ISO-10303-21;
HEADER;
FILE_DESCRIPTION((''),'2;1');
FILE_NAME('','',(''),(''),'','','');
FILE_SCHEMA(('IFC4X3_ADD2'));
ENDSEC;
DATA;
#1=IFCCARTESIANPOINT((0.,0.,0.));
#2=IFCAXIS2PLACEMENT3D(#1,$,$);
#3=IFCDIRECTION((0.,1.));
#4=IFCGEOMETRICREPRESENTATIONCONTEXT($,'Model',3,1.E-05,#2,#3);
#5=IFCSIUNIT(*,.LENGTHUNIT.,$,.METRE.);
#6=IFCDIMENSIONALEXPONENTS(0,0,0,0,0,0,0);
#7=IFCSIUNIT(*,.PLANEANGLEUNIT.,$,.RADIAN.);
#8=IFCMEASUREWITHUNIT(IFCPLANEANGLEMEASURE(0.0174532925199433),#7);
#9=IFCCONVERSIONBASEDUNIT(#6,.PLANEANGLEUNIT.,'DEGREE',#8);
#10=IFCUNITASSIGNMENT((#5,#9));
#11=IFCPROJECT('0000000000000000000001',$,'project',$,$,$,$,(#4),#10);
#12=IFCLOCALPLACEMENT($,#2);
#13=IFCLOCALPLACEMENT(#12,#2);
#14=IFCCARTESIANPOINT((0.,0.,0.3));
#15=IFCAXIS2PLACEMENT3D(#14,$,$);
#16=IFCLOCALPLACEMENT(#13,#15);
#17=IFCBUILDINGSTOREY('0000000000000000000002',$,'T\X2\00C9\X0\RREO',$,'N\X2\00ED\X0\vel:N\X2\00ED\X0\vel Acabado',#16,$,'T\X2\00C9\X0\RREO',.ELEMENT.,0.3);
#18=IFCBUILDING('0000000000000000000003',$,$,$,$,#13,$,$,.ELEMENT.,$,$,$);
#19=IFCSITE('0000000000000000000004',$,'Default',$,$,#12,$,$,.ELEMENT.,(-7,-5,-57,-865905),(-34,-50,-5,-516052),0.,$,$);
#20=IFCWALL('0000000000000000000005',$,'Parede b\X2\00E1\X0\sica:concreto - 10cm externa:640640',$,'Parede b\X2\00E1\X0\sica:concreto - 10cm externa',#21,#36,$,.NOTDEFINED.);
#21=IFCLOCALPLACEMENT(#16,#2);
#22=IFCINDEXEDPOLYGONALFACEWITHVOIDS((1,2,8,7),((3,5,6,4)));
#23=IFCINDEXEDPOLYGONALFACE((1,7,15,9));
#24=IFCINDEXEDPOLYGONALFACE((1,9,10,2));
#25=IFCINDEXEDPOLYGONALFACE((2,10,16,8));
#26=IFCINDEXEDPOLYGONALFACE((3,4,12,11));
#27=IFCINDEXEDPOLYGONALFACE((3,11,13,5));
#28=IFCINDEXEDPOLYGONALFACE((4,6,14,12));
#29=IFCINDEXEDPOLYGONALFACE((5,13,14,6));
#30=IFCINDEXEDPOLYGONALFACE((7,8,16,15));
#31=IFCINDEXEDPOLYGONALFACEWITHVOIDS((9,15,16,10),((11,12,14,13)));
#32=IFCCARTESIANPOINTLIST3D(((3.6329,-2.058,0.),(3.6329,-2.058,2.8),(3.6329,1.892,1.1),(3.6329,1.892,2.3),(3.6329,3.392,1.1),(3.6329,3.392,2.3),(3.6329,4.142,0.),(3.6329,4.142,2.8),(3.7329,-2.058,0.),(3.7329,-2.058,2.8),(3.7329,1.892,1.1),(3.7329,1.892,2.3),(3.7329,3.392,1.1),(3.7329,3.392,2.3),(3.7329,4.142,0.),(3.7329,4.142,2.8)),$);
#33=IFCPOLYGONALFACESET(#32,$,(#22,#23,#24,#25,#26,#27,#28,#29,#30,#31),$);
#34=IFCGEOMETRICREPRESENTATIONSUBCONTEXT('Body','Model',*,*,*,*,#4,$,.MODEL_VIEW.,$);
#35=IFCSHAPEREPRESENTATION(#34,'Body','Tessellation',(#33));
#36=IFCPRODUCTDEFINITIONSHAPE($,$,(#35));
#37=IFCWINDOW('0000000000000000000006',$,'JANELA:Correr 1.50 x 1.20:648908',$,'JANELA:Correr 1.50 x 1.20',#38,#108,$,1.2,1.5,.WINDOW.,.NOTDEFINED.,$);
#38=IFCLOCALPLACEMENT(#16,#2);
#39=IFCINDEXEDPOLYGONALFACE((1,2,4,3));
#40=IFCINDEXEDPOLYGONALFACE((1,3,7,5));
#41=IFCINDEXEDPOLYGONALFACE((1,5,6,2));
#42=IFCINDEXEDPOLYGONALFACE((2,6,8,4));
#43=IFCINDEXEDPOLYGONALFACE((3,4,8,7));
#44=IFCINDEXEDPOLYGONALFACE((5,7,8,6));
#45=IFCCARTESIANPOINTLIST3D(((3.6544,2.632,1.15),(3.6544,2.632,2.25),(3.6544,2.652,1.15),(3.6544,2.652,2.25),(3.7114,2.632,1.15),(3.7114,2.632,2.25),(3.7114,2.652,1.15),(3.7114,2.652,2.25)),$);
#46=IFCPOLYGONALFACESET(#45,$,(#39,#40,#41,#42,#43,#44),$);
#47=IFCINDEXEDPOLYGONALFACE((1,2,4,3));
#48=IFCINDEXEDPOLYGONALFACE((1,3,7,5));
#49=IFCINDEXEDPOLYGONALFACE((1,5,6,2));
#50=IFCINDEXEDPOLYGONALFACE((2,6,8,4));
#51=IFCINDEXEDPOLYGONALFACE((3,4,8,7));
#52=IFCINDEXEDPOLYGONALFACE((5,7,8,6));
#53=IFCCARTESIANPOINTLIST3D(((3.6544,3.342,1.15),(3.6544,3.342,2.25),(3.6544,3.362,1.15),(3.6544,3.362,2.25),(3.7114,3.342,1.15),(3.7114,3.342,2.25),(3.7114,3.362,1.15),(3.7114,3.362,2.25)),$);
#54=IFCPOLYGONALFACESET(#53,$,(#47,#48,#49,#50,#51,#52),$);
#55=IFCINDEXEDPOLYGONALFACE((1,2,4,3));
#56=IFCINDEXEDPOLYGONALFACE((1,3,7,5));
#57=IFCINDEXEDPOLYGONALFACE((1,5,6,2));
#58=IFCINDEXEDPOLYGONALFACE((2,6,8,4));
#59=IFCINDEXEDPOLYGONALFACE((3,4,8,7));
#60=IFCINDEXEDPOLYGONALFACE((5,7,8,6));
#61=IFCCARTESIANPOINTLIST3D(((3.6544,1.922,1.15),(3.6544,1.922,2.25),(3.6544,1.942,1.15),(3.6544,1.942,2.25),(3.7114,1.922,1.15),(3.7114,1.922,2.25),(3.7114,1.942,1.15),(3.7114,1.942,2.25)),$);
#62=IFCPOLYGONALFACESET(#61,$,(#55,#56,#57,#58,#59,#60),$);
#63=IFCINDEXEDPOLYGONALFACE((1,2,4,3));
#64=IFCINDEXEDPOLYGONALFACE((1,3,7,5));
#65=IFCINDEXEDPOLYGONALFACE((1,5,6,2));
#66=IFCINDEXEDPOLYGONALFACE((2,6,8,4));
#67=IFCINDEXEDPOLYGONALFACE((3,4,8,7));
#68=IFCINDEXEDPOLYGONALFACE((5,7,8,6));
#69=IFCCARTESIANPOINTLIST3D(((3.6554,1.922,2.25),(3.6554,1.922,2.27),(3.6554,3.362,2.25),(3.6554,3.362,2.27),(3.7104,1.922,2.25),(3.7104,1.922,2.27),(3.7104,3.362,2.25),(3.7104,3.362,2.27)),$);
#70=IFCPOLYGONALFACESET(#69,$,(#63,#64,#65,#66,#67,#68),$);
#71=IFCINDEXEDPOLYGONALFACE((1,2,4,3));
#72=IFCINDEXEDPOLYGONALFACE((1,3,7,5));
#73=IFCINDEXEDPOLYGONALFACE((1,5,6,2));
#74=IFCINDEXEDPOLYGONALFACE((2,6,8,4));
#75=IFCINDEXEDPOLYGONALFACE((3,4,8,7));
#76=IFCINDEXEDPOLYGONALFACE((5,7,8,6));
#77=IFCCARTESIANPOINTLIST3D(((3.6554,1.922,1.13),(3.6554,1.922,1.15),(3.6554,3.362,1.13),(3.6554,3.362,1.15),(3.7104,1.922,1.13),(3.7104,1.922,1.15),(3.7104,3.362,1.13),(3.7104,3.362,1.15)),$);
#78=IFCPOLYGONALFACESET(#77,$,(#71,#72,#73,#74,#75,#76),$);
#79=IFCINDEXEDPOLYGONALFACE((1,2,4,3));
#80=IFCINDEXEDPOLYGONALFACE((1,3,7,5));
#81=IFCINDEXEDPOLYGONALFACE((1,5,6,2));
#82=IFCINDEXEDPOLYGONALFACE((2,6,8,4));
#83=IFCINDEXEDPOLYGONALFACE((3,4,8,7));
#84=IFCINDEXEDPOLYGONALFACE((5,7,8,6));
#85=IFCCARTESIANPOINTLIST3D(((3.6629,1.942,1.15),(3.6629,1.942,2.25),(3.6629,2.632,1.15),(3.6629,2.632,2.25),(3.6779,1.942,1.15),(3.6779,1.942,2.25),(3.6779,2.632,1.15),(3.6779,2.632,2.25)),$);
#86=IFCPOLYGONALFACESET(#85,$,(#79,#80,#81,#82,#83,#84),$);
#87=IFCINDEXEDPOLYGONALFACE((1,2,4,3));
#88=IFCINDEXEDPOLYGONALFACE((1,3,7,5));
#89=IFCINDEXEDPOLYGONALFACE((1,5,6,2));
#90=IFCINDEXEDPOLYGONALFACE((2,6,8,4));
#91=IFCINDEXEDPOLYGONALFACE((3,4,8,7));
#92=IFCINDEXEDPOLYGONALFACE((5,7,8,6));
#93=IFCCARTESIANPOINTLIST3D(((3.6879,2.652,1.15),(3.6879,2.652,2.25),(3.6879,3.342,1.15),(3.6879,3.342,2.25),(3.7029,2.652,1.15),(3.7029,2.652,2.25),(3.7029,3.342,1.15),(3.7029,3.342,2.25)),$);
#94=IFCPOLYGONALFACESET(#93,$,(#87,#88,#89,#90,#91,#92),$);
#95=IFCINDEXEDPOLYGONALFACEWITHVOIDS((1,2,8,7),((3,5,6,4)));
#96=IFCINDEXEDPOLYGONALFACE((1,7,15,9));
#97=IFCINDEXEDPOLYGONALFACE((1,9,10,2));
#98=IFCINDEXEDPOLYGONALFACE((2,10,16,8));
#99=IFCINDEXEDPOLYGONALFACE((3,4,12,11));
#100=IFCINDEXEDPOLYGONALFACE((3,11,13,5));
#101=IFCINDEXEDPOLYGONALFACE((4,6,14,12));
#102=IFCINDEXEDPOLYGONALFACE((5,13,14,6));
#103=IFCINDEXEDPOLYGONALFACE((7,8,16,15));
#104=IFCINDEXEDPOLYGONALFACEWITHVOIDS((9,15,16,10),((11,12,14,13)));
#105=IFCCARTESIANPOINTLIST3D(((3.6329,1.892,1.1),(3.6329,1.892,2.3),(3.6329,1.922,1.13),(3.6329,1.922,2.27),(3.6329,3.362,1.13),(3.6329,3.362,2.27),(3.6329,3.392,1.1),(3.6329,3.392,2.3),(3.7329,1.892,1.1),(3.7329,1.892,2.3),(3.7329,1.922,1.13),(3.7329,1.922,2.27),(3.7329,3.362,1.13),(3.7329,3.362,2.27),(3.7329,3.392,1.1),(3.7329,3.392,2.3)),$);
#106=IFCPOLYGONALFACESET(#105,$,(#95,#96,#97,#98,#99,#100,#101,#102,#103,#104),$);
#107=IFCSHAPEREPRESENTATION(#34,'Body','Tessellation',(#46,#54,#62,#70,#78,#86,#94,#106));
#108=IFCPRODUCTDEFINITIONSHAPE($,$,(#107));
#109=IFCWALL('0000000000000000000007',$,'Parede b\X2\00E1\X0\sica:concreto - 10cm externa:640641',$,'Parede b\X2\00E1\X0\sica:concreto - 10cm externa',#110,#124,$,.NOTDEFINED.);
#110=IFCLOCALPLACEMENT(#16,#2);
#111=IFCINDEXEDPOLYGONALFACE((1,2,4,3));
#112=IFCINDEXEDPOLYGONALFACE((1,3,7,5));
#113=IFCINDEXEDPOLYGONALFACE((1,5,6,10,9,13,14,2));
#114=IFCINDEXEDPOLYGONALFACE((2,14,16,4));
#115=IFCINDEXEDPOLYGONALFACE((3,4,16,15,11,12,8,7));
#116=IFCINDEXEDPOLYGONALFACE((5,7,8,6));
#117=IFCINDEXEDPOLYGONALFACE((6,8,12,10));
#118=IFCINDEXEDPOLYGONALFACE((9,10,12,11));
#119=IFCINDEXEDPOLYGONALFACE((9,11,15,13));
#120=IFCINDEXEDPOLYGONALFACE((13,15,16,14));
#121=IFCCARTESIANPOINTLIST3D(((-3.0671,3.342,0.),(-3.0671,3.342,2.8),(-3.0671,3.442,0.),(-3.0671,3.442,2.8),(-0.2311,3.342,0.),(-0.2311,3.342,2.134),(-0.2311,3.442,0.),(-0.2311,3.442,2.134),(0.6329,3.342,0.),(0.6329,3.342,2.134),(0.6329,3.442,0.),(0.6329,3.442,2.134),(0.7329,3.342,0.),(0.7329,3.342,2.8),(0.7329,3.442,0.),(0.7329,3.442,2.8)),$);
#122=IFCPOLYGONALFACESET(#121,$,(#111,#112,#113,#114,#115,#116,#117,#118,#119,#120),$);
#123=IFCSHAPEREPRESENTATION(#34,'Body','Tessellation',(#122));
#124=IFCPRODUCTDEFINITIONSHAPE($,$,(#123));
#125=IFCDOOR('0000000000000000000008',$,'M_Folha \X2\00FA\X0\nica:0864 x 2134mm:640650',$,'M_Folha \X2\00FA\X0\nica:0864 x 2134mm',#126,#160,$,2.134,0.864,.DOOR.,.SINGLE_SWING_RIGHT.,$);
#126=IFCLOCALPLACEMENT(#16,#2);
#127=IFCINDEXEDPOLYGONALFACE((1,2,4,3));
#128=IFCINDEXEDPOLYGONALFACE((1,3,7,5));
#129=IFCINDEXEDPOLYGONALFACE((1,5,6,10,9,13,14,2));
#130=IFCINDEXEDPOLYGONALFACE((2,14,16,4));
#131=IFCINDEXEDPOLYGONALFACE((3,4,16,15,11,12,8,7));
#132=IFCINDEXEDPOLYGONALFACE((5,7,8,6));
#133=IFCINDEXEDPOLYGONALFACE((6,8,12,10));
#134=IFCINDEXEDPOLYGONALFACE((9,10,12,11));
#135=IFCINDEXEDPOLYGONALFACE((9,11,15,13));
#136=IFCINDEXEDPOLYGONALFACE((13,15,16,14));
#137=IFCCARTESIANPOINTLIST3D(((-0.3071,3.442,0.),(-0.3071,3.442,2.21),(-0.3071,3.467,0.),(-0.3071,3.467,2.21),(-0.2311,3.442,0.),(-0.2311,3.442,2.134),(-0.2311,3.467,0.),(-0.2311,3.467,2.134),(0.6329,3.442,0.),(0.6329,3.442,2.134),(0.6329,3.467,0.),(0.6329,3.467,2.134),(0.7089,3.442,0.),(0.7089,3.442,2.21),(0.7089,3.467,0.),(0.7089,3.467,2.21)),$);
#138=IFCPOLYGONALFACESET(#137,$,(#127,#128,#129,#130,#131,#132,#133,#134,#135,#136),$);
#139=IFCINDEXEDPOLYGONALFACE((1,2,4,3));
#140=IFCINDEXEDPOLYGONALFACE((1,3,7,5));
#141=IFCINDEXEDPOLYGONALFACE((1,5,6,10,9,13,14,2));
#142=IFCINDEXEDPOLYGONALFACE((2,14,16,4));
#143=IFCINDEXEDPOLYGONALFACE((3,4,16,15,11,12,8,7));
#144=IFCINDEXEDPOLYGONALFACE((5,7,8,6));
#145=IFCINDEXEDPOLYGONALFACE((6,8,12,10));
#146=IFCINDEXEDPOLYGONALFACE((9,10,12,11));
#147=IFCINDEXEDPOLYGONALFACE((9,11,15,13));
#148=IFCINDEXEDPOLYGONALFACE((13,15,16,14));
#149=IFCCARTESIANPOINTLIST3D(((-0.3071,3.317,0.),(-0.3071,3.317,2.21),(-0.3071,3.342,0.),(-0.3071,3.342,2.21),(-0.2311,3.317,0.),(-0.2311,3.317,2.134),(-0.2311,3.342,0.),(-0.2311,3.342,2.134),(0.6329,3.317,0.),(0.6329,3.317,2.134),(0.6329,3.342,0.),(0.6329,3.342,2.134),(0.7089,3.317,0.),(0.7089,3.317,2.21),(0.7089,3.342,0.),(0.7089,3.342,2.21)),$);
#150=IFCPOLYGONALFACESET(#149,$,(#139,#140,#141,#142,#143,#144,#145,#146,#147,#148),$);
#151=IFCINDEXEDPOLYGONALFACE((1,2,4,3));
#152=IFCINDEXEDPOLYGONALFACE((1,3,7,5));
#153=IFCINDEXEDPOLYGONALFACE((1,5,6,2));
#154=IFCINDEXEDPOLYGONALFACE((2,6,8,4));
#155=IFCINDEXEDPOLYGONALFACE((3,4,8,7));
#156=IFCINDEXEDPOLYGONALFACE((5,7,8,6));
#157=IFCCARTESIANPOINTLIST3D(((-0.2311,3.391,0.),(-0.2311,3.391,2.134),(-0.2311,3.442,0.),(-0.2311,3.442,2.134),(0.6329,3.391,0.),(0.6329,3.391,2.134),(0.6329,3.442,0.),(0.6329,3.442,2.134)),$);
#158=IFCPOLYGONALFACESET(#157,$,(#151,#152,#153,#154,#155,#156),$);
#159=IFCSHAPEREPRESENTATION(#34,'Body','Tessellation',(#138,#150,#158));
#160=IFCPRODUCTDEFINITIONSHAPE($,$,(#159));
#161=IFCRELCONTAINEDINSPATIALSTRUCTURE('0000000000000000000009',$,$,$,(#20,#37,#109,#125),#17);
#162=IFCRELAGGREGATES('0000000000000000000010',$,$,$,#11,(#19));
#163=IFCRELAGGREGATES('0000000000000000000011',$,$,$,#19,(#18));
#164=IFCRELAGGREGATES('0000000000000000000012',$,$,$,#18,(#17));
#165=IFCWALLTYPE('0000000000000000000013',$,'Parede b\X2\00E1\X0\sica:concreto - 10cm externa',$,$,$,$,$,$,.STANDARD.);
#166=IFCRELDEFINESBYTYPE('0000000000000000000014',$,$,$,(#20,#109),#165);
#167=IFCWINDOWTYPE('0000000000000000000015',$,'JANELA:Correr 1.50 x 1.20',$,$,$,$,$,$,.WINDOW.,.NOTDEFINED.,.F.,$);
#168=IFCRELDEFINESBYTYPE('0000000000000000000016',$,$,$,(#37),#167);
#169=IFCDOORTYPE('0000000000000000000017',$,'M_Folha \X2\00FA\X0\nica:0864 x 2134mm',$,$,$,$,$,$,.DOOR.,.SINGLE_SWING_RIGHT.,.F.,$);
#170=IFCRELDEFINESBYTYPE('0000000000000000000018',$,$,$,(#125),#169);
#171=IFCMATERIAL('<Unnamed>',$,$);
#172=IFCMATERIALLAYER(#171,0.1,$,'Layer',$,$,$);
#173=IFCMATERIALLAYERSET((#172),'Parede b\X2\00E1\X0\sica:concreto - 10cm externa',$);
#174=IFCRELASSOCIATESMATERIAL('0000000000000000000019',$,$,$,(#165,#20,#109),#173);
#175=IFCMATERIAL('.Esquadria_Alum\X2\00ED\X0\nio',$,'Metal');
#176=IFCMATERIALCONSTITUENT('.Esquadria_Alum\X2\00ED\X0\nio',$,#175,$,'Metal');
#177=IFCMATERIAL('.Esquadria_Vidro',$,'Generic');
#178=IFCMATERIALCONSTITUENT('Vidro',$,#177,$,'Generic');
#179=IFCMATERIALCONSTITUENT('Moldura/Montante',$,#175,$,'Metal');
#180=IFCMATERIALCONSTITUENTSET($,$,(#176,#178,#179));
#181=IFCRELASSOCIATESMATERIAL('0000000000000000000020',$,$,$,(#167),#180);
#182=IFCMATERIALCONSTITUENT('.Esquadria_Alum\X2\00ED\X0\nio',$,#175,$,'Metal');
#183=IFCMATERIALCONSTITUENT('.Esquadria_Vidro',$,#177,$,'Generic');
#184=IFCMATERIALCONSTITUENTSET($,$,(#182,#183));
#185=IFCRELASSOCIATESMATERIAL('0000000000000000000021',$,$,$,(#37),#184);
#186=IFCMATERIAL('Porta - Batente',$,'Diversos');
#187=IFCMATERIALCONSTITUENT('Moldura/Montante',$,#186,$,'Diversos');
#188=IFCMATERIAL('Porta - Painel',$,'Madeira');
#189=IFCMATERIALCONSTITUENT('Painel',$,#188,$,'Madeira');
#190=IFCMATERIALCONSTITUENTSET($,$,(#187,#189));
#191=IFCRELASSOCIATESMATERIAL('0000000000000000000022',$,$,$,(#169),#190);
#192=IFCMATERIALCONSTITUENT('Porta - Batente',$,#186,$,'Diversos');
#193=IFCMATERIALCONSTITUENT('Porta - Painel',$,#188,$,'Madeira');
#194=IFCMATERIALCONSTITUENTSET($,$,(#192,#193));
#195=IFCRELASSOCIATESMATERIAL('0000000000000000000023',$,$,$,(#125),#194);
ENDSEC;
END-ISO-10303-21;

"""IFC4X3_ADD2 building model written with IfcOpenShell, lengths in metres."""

from ifc_helpers import new_model, entity, si_unit, converted_unit, direction, frame, frame_2d, origin, origin_2d_with_axis, place, context, subcontext, project, spatial, polyline, rectangle, outline, extrude, source, transform, mapped, material, layer, layer_set, constituent, constituent_set, type_object, type_shapes, element, fill, save


model = new_model("IFC4X3_ADD2")

# Units and contexts
model_context = context("Model", 3, precision=1e-05, world=origin(), true_north=direction((0.0, 1.0)))
body_context = subcontext(model_context, "Body", "Model", "MODEL_VIEW")
ifc_project = project(units=[si_unit("LENGTHUNIT", "METRE"), converted_unit("PLANEANGLEUNIT", "DEGREE", entity("IfcPlaneAngleMeasure", 0.0174532925199433), si_unit("PLANEANGLEUNIT", "RADIAN"), dimensions=[0, 0, 0, 0, 0, 0, 0])], contexts=[model_context])

# Site, building, storey
site_placement = place(None, origin())
site = spatial("IfcSite", under=ifc_project, at=site_placement, Name="Default", CompositionType="ELEMENT", RefLatitude=(-7, -5, -57, -865905), RefLongitude=(-34, -50, -5, -516052), RefElevation=0.0)
building_placement = place(site_placement, origin())
building = spatial("IfcBuilding", under=site, at=building_placement, CompositionType="ELEMENT")
storey_placement = place(building_placement, frame((0.0, 0.0, 0.3)))
storey = spatial("IfcBuildingStorey", under=building, at=storey_placement, Name="TÉRREO", ObjectType="Nível:Nível Acabado", LongName="TÉRREO", CompositionType="ELEMENT", Elevation=0.3)

# Shared definitions
ifc_material_1 = material(Name="<Unnamed>")
ifc_layer_1 = layer(ifc_material_1, 0.1, Name="Layer")
ifc_layer_set_1 = layer_set([ifc_layer_1], Name="Parede básica:concreto - 10cm externa")
wall_type_1 = type_object("IfcWallType", Name="Parede básica:concreto - 10cm externa", PredefinedType="STANDARD", material=ifc_layer_set_1)
ifc_material_2 = material(Name=".Esquadria_Alumínio", Category="Metal")
ifc_material_3 = material(Name=".Esquadria_Vidro", Category="Generic")
ifc_constituent_1 = constituent(ifc_material_2, Name=".Esquadria_Alumínio", Category="Metal")
ifc_constituent_2 = constituent(ifc_material_3, Name="Vidro", Category="Generic")
ifc_constituent_3 = constituent(ifc_material_2, Name="Moldura/Montante", Category="Metal")
ifc_constituent_set_1 = constituent_set(constituents=[ifc_constituent_1, ifc_constituent_2, ifc_constituent_3])
window_type_1 = type_object("IfcWindowType", Name="JANELA:Correr 1.50 x 1.20", ParameterTakesPrecedence=False, PartitioningType="NOTDEFINED", PredefinedType="WINDOW", material=ifc_constituent_set_1)
shared_shape_1 = source(origin(), body_context, "Body", "SweptSolid", [
    extrude(rectangle(XDim=0.02, YDim=0.057, at=origin_2d_with_axis()), frame((0.75, 0.05, 0.05), z_axis=(0.0, 0.0, 1.0), x_axis=(-1.0, 0.0, 0.0)), (0.0, 0.0, 1.0), 1.1),
    extrude(rectangle(XDim=0.02, YDim=0.057, at=origin_2d_with_axis()), frame((0.04, 0.05, 0.05), z_axis=(0.0, 0.0, 1.0), x_axis=(-1.0, 0.0, 0.0)), (0.0, 0.0, 1.0), 1.1),
    extrude(rectangle(XDim=0.02, YDim=0.057, at=origin_2d_with_axis()), frame((1.46, 0.05, 0.05), z_axis=(0.0, 0.0, 1.0), x_axis=(-1.0, 0.0, 0.0)), (0.0, 0.0, 1.0), 1.1),
    extrude(rectangle(XDim=1.44, YDim=0.055, at=origin_2d_with_axis()), frame((0.75, 0.05, 1.15), z_axis=(0.0, 0.0, 1.0), x_axis=(-1.0, 0.0, 0.0)), (0.0, 0.0, 1.0), 0.02),
    extrude(rectangle(XDim=1.44, YDim=0.055, at=origin_2d_with_axis()), frame((0.75, 0.05, 0.03), z_axis=(0.0, 0.0, 1.0), x_axis=(-1.0, 0.0, 0.0)), (0.0, 0.0, 1.0), 0.02),
    extrude(rectangle(XDim=0.015, YDim=0.69, at=frame_2d((0.0, 0.0), x_axis=(1.0, 0.0))), frame((1.105, 0.0375, 0.05), z_axis=(0.0, 0.0, 1.0), x_axis=(0.0, 1.0, 0.0)), (0.0, 0.0, 1.0), 1.1),
    extrude(rectangle(XDim=0.015, YDim=0.69, at=origin_2d_with_axis()), frame((0.395, 0.0625, 0.05), z_axis=(0.0, 0.0, 1.0), x_axis=(0.0, 1.0, 0.0)), (0.0, 0.0, 1.0), 1.1),
    extrude(outline(polyline([(-0.75, -0.6), (0.75, -0.6), (0.75, 0.6), (-0.75, 0.6), (-0.75, -0.6)]), holes=[polyline([(0.72, -0.57), (-0.72, -0.57), (-0.72, 0.57), (0.72, 0.57), (0.72, -0.57)])]), frame((0.75, 0.0, 0.6), z_axis=(0.0, 1.0, 0.0), x_axis=(1.0, 0.0, 0.0)), (0.0, 0.0, 1.0), 0.1),
])
type_shapes(window_type_1, [shared_shape_1])

# Wall, opening, window
wall_1_placement = place(storey_placement, frame((3.6829, 4.142, 0.0), z_axis=(0.0, 0.0, 1.0), x_axis=(0.0, -1.0, 0.0)))
wall_1 = element("IfcWall", 1, at=wall_1_placement, inside=storey, type_object=wall_type_1, material=ifc_layer_set_1, Name="Parede básica:concreto - 10cm externa:640640", ObjectType="Parede básica:concreto - 10cm externa", PredefinedType="NOTDEFINED", context=body_context, shape_type="SweptSolid", body=[
    extrude(rectangle(XDim=6.2, YDim=0.1, at=frame_2d((3.1, 0.0), x_axis=(-1.0, 0.0))), origin(), (0.0, 0.0, 1.0), 2.8),
])
opening_1_placement = place(wall_1_placement, frame((0.75, -0.05, 1.1)))
opening_1 = element("IfcOpeningElement", 2, at=opening_1_placement, cuts=wall_1, PredefinedType="OPENING", context=body_context, shape_type="SweptSolid", body=[
    extrude(rectangle(XDim=1.2, YDim=1.5, at=frame_2d((0.6, 0.75), x_axis=(1.0, 0.0))), frame((0.0, 0.0, 0.0), z_axis=(0.0, 1.0, 0.0), x_axis=(0.0, 0.0, 1.0)), (0.0, 0.0, 1.0), 0.1),
])
ifc_constituent_4 = constituent(ifc_material_2, Name=".Esquadria_Alumínio", Category="Metal")
ifc_constituent_5 = constituent(ifc_material_3, Name=".Esquadria_Vidro", Category="Generic")
ifc_constituent_set_2 = constituent_set(constituents=[ifc_constituent_4, ifc_constituent_5])
window_1_placement = place(opening_1_placement, origin())
window_1 = element("IfcWindow", 3, at=window_1_placement, inside=storey, type_object=window_type_1, material=ifc_constituent_set_2, Name="JANELA:Correr 1.50 x 1.20:648908", ObjectType="JANELA:Correr 1.50 x 1.20", OverallHeight=1.2, OverallWidth=1.5, PartitioningType="NOTDEFINED", PredefinedType="WINDOW", context=body_context, shape_type="MappedRepresentation", body=[
    mapped(shared_shape_1, transform((0.0, 0.0, 0.0), scale=1.0)),
])
fill(opening_1, window_1)

# Wall, opening, door
wall_2_placement = place(storey_placement, frame((-3.0671, 3.392, 0.0)))
wall_2 = element("IfcWall", 4, at=wall_2_placement, inside=storey, type_object=wall_type_1, material=ifc_layer_set_1, Name="Parede básica:concreto - 10cm externa:640641", ObjectType="Parede básica:concreto - 10cm externa", PredefinedType="NOTDEFINED", context=body_context, shape_type="SweptSolid", body=[
    extrude(rectangle(XDim=3.8, YDim=0.1, at=frame_2d((1.9, 0.0), x_axis=(-1.0, 0.0))), origin(), (0.0, 0.0, 1.0), 2.8),
])
opening_2_placement = place(wall_2_placement, frame((2.836, -0.05, 0.0)))
opening_2 = element("IfcOpeningElement", 5, at=opening_2_placement, cuts=wall_2, PredefinedType="OPENING", context=body_context, shape_type="SweptSolid", body=[
    extrude(rectangle(XDim=0.864, YDim=2.134, at=frame_2d((1.067, 0.432), x_axis=(0.0, 1.0))), frame((0.0, 0.0, 0.0), z_axis=(0.0, 1.0, 0.0), x_axis=(0.0, 0.0, 1.0)), (0.0, 0.0, 1.0), 0.1),
])
ifc_material_4 = material(Name="Porta - Batente", Category="Diversos")
ifc_constituent_6 = constituent(ifc_material_4, Name="Porta - Batente", Category="Diversos")
ifc_material_5 = material(Name="Porta - Painel", Category="Madeira")
ifc_constituent_7 = constituent(ifc_material_5, Name="Porta - Painel", Category="Madeira")
ifc_constituent_set_3 = constituent_set(constituents=[ifc_constituent_6, ifc_constituent_7])
ifc_constituent_8 = constituent(ifc_material_4, Name="Moldura/Montante", Category="Diversos")
ifc_constituent_9 = constituent(ifc_material_5, Name="Painel", Category="Madeira")
ifc_constituent_set_4 = constituent_set(constituents=[ifc_constituent_8, ifc_constituent_9])
door_type_1 = type_object("IfcDoorType", Name="M_Folha única:0864 x 2134mm", OperationType="SINGLE_SWING_RIGHT", ParameterTakesPrecedence=False, PredefinedType="DOOR", material=ifc_constituent_set_4)
shared_shape_2 = source(origin(), body_context, "Body", "SweptSolid", [
    extrude(outline(polyline([(-0.508, -1.124), (0.508, -1.124), (0.508, 1.086), (0.432, 1.086), (0.432, -1.048), (-0.432, -1.048), (-0.432, 1.086), (-0.508, 1.086), (-0.508, -1.124)])), frame((0.432, 0.1, 1.086), z_axis=(0.0, 1.0, 0.0), x_axis=(1.0, 0.0, 0.0)), (0.0, 0.0, 1.0), 0.025),
    extrude(outline(polyline([(-1.124, -0.508), (1.086, -0.508), (1.086, -0.432), (-1.048, -0.432), (-1.048, 0.432), (1.086, 0.432), (1.086, 0.508), (-1.124, 0.508), (-1.124, -0.508)])), frame((0.432, -0.025, 1.086), z_axis=(0.0, 1.0, 0.0), x_axis=(0.0, 0.0, -1.0)), (0.0, 0.0, 1.0), 0.025),
    extrude(rectangle(XDim=0.051, YDim=0.864, at=origin_2d_with_axis()), frame((0.432, 0.0745, 0.0), z_axis=(0.0, 0.0, 1.0), x_axis=(0.0, 1.0, 0.0)), (0.0, 0.0, 1.0), 2.134),
])
type_shapes(door_type_1, [shared_shape_2])
door_1_placement = place(opening_2_placement, origin())
door_1 = element("IfcDoor", 6, at=door_1_placement, inside=storey, type_object=door_type_1, material=ifc_constituent_set_3, Name="M_Folha única:0864 x 2134mm:640650", ObjectType="M_Folha única:0864 x 2134mm", OperationType="SINGLE_SWING_RIGHT", OverallHeight=2.134, OverallWidth=0.864, PredefinedType="DOOR", context=body_context, shape_type="MappedRepresentation", body=[
    mapped(shared_shape_2, transform((0.0, 0.0, 0.0), scale=1.0)),
])
fill(opening_2, door_1)

save(model, "model.ifc")
